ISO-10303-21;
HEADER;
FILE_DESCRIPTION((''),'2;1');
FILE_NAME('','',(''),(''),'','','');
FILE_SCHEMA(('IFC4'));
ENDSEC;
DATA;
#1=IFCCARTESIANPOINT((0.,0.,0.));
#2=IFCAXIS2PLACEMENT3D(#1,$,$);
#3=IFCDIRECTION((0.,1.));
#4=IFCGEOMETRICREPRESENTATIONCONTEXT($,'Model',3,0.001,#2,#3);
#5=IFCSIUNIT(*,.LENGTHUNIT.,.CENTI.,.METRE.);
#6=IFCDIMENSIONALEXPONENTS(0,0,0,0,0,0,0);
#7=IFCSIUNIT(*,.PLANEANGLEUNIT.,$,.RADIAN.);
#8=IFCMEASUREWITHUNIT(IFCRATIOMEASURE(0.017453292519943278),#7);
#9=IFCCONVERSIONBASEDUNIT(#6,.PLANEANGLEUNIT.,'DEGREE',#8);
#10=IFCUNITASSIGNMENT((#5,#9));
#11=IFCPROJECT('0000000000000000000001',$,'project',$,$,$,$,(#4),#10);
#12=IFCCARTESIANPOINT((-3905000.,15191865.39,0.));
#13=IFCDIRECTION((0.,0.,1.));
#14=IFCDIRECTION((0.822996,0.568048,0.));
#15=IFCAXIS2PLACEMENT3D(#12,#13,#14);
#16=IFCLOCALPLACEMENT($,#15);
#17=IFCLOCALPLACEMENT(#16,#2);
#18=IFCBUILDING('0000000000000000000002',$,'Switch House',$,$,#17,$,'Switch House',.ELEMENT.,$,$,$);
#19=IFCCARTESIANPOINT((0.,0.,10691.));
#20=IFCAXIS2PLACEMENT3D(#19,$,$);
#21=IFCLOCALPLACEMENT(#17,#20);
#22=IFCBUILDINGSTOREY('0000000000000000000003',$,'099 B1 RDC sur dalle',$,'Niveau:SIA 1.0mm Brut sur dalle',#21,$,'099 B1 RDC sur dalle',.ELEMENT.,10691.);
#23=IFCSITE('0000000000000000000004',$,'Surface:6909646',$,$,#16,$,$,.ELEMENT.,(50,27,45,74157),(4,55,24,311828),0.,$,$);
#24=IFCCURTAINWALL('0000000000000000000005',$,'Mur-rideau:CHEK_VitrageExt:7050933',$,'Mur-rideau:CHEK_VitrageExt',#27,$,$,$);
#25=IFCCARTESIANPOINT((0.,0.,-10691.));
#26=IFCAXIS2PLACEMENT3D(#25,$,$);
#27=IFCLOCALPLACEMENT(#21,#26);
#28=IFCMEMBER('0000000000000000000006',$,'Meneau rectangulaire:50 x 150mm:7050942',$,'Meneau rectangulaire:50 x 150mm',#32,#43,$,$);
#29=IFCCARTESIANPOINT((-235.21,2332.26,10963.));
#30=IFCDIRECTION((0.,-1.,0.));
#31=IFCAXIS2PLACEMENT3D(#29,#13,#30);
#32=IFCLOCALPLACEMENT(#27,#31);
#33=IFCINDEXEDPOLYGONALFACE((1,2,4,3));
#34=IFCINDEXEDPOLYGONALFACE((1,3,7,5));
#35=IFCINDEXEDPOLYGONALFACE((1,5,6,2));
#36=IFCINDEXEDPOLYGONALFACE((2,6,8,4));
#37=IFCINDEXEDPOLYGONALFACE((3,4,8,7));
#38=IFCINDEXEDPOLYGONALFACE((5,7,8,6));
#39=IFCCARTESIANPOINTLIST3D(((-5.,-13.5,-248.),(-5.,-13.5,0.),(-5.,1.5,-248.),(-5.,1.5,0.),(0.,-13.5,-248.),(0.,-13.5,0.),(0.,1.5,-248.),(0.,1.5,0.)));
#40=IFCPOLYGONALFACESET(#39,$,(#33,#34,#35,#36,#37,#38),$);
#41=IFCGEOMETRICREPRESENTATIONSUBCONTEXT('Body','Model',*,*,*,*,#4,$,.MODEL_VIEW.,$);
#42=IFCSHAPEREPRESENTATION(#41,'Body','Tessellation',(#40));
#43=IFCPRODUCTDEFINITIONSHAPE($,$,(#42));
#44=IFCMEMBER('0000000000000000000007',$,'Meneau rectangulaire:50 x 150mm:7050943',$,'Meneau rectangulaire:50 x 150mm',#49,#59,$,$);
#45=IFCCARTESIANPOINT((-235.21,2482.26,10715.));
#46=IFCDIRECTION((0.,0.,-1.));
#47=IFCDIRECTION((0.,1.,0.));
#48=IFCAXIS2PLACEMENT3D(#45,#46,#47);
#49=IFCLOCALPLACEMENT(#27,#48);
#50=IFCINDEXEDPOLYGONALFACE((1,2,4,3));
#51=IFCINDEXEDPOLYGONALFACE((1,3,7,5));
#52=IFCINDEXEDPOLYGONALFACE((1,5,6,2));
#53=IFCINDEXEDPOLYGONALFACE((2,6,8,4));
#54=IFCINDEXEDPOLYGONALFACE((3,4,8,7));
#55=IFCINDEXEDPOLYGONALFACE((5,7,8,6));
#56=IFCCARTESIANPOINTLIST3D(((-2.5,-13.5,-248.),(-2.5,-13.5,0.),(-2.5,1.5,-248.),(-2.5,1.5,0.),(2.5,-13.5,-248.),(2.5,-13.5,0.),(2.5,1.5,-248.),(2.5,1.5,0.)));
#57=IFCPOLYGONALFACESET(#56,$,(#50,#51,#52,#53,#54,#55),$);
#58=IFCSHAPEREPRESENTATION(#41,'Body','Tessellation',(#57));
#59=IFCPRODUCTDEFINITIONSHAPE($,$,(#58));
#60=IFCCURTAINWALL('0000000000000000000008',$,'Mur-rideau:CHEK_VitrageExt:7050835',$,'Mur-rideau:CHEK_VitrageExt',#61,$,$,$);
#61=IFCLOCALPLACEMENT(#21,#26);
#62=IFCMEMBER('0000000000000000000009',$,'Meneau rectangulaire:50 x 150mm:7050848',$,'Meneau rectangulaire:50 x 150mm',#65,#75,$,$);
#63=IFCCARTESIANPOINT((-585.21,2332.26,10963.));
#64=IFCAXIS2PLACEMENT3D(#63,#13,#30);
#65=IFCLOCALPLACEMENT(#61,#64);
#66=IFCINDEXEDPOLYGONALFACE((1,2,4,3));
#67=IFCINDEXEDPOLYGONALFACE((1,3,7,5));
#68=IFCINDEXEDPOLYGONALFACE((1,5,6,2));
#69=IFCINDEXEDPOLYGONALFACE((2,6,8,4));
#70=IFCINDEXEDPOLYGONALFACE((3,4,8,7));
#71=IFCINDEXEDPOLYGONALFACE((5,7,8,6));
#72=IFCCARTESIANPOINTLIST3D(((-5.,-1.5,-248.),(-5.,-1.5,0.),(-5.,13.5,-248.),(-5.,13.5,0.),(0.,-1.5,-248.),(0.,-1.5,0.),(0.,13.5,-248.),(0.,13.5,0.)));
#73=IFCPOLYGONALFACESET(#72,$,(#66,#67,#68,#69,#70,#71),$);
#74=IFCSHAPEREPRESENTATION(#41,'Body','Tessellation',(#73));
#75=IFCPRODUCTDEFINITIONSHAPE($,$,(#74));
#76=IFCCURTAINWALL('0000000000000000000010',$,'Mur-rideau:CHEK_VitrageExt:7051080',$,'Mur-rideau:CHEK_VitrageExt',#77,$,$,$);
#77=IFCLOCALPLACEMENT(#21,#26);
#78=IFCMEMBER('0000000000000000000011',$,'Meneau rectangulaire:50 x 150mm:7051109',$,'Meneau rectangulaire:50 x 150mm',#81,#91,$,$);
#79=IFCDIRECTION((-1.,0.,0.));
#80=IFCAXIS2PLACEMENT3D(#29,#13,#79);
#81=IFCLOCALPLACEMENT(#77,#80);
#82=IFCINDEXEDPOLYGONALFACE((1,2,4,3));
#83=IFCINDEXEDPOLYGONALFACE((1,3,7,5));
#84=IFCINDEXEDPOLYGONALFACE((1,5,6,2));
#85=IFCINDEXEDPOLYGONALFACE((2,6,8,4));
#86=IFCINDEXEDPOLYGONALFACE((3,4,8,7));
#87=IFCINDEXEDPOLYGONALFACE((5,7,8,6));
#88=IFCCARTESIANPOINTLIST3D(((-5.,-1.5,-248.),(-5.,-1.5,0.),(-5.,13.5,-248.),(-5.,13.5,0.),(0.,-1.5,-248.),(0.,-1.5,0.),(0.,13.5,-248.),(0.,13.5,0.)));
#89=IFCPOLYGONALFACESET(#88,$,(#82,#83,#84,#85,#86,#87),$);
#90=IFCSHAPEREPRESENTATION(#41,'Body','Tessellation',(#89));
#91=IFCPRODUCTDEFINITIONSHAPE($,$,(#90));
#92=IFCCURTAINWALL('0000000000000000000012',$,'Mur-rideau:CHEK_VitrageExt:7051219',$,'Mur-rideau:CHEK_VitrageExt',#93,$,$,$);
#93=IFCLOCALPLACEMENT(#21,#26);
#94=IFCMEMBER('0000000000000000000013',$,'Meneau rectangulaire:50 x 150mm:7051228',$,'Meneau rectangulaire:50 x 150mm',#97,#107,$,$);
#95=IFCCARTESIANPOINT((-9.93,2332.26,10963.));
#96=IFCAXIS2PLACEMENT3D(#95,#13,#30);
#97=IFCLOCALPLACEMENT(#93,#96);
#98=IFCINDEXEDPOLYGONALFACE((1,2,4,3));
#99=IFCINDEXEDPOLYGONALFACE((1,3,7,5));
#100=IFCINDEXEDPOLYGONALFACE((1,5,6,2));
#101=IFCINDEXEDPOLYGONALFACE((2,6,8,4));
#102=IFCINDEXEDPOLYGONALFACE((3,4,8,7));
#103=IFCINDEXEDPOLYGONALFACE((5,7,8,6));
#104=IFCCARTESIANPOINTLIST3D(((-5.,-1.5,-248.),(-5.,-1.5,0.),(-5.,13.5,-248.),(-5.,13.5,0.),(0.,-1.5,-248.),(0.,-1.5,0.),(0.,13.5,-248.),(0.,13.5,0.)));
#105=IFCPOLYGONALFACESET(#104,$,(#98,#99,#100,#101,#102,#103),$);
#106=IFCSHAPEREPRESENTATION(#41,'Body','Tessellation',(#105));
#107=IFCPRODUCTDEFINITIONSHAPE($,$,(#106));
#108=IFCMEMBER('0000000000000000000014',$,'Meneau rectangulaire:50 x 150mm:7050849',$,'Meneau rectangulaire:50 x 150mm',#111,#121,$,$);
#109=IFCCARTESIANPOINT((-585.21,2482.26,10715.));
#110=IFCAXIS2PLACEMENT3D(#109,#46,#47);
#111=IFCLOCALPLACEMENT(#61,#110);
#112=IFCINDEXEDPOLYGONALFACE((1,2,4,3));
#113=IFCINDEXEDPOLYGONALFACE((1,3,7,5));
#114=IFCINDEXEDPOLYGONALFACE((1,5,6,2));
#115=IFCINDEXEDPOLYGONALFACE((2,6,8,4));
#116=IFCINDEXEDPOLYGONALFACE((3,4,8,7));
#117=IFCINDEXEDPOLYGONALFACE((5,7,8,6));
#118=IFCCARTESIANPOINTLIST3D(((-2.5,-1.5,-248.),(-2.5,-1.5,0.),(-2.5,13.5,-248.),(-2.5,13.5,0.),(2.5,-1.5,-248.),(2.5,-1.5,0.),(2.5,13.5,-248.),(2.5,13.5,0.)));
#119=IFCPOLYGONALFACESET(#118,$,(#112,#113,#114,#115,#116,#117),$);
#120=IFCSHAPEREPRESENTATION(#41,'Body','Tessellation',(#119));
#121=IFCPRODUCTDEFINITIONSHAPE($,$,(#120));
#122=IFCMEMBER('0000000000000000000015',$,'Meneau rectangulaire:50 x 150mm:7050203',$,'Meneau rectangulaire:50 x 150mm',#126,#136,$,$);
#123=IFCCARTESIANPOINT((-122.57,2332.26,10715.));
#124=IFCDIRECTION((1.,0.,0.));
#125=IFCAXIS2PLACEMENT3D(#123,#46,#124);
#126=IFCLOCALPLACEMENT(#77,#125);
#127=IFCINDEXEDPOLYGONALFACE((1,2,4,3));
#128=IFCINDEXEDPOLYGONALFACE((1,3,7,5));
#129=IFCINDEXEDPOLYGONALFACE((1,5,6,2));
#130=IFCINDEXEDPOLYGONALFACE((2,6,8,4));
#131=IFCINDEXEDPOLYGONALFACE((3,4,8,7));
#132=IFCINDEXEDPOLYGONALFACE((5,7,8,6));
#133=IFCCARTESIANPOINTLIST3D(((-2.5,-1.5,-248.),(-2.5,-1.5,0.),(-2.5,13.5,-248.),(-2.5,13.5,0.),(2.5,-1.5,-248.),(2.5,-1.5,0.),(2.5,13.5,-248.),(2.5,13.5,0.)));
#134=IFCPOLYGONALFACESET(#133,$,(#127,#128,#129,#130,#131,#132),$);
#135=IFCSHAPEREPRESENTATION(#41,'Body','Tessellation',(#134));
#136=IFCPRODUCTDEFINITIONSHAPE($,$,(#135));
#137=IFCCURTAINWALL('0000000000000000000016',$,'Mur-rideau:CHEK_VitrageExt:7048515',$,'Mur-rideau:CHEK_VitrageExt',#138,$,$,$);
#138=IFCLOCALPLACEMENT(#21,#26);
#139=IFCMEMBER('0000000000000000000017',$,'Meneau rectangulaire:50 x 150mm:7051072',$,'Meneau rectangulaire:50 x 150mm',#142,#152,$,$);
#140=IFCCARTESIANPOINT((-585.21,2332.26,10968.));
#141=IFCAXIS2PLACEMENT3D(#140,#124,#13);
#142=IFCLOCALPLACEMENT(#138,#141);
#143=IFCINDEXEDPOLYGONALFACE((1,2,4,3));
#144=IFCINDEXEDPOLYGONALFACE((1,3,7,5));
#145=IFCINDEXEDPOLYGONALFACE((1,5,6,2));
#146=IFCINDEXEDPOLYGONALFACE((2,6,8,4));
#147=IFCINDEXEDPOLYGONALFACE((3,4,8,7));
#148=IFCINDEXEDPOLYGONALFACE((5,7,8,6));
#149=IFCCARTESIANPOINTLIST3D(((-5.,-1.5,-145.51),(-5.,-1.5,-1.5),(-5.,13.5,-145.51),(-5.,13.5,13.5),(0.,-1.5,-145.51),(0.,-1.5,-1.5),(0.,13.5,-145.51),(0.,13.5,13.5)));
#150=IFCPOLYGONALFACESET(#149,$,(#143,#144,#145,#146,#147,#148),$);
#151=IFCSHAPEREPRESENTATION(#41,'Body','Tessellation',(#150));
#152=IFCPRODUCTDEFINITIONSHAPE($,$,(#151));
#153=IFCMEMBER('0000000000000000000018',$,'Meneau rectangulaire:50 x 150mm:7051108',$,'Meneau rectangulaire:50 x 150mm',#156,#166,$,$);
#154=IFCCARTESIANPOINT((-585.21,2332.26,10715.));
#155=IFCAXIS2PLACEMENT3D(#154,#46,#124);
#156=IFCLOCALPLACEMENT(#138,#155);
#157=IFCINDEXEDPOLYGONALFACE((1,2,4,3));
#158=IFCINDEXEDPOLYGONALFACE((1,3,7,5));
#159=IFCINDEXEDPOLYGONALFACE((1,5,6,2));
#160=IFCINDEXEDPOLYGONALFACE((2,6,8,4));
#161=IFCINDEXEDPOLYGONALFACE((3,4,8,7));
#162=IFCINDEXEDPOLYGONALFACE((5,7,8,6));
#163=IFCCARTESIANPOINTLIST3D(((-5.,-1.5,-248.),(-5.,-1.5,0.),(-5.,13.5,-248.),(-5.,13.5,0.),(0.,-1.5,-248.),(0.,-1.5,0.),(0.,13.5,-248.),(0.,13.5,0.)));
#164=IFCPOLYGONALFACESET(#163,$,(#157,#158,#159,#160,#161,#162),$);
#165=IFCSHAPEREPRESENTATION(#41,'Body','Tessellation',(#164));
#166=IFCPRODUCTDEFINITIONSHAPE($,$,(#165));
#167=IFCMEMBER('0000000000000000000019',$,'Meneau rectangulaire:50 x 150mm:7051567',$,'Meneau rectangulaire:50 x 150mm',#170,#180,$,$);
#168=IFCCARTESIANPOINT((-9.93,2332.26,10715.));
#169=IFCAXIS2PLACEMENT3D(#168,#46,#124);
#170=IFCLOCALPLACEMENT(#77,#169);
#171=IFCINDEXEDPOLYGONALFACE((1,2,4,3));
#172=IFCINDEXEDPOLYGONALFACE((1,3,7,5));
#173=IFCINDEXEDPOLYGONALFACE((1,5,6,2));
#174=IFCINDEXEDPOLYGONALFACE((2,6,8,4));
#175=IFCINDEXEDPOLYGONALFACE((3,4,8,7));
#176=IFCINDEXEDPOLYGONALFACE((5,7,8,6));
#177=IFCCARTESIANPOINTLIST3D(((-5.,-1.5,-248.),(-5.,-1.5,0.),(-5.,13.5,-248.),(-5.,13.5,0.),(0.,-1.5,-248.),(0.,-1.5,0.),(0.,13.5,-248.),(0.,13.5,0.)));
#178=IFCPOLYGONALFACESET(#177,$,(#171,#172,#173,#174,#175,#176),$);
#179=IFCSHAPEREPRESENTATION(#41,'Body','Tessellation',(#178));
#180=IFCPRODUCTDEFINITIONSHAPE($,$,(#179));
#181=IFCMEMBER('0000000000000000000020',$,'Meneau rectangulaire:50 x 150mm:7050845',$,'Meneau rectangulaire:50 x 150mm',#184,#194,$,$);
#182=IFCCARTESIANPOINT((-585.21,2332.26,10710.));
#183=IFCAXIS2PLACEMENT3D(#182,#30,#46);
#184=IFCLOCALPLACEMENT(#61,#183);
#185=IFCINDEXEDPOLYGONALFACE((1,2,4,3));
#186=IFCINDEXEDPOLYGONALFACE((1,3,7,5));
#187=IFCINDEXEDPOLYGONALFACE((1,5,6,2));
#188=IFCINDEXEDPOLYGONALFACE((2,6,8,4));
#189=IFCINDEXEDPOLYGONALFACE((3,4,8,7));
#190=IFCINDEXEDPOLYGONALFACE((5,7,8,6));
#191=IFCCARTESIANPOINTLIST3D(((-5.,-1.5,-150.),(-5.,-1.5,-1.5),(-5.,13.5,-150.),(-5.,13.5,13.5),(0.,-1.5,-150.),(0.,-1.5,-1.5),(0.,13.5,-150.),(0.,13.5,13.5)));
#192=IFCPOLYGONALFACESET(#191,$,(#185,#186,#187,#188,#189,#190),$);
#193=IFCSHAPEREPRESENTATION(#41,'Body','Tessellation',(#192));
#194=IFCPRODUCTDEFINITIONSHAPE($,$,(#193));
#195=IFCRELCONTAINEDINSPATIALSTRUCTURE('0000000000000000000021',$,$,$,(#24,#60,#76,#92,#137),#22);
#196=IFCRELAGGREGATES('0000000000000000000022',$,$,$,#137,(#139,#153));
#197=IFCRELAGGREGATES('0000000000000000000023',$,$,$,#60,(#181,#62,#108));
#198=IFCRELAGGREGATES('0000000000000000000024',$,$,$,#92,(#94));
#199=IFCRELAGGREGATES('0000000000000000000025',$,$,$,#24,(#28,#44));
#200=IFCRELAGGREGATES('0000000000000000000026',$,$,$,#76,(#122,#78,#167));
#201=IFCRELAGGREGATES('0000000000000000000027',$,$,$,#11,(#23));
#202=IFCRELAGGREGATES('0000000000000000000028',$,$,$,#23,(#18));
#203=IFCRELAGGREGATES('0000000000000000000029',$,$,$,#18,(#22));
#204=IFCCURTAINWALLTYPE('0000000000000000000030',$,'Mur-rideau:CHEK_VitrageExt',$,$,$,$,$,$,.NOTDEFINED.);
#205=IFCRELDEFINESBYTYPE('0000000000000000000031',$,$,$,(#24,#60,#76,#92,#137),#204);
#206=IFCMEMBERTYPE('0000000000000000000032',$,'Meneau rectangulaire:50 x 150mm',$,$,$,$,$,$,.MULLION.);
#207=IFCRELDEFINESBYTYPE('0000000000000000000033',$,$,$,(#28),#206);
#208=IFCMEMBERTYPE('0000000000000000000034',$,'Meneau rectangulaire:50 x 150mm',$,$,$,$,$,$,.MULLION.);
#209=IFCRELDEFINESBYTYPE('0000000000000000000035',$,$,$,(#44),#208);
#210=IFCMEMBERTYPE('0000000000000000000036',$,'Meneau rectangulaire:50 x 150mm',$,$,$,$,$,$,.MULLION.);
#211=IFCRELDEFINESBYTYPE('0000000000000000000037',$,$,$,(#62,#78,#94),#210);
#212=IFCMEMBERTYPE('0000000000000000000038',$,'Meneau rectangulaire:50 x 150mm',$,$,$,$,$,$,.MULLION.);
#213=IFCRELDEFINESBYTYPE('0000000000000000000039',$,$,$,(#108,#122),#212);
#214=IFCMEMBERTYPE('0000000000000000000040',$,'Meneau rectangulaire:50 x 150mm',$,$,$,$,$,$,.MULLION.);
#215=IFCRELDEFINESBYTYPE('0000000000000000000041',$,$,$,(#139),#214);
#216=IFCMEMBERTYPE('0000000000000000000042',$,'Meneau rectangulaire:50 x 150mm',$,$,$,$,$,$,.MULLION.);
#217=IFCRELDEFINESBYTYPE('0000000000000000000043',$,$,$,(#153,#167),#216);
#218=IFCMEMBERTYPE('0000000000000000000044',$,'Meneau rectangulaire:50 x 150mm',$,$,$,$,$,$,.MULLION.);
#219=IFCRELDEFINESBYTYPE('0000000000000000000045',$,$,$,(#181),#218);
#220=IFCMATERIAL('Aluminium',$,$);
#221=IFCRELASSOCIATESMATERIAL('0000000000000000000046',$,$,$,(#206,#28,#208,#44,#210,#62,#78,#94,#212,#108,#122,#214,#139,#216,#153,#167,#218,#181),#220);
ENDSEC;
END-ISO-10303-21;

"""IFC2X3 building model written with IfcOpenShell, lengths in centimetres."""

from ifc_helpers import new_model, entity, si_unit, converted_unit, direction, frame, origin, origin_2d_with_axis, place, context, subcontext, project, spatial, rectangle, extrude, clip, halfspace, source, transform, mapped, material, type_object, type_shapes, element, aggregate, save


model = new_model("IFC2X3")

# Units and contexts
model_context = context("Model", 3, precision=0.001, world=origin(), true_north=direction((0.0, 1.0)))
body_context = subcontext(model_context, "Body", "Model", "MODEL_VIEW")
ifc_project = project(units=[si_unit("LENGTHUNIT", "METRE", prefix="CENTI"), converted_unit("PLANEANGLEUNIT", "DEGREE", entity("IfcRatioMeasure", 0.017453292519943278), si_unit("PLANEANGLEUNIT", "RADIAN"), dimensions=[0, 0, 0, 0, 0, 0, 0])], contexts=[model_context])

# Site, building, storey
site_placement = place(None, frame((-3905000.0, 15191865.39, 0.0), z_axis=(0.0, 0.0, 1.0), x_axis=(0.822996, 0.568048, 0.0)))
site = spatial("IfcSite", under=ifc_project, at=site_placement, Name="Surface:6909646", CompositionType="ELEMENT", RefLatitude=(50, 27, 45, 74157), RefLongitude=(4, 55, 24, 311828), RefElevation=0.0)
building_placement = place(site_placement, origin())
building = spatial("IfcBuilding", under=site, at=building_placement, Name="Switch House", LongName="Switch House", CompositionType="ELEMENT")
storey_placement = place(building_placement, frame((0.0, 0.0, 10691.0)))
storey = spatial("IfcBuildingStorey", under=building, at=storey_placement, Name="099 B1 RDC sur dalle", ObjectType="Niveau:SIA 1.0mm Brut sur dalle", LongName="099 B1 RDC sur dalle", CompositionType="ELEMENT", Elevation=10691.0)

# Curtain wall, members
curtain_wall_type = type_object("IfcCurtainWallType", Name="Mur-rideau:CHEK_VitrageExt", PredefinedType="NOTDEFINED")
curtain_wall_1_placement = place(storey_placement, frame((0.0, 0.0, -10691.0)))
curtain_wall_1 = element("IfcCurtainWall", 1, at=curtain_wall_1_placement, inside=storey, type_object=curtain_wall_type, Name="Mur-rideau:CHEK_VitrageExt:7050933", ObjectType="Mur-rideau:CHEK_VitrageExt")
ifc_material_1 = material(Name="Aluminium")
member_type_1 = type_object("IfcMemberType", Name="Meneau rectangulaire:50 x 150mm", PredefinedType="MULLION", material=ifc_material_1)
shared_shape_1 = source(origin(), body_context, "Body", "SweptSolid", [
    extrude(rectangle(XDim=15.0, YDim=5.0, at=origin_2d_with_axis()), frame((-2.5, -6.0, -248.0), z_axis=(0.0, 0.0, 1.0), x_axis=(0.0, -1.0, 0.0)), (0.0, 0.0, 1.0), 248.0),
])
type_shapes(member_type_1, [shared_shape_1])
member_1_placement = place(curtain_wall_1_placement, frame((-235.21, 2332.26, 10963.0), z_axis=(0.0, 0.0, 1.0), x_axis=(0.0, -1.0, 0.0)))
member_1 = element("IfcMember", 2, at=member_1_placement, type_object=member_type_1, material=ifc_material_1, Name="Meneau rectangulaire:50 x 150mm:7050942", ObjectType="Meneau rectangulaire:50 x 150mm", context=body_context, shape_type="MappedRepresentation", body=[
    mapped(shared_shape_1, transform((0.0, 0.0, 0.0), scale=1.0)),
])
member_type_2 = type_object("IfcMemberType", Name="Meneau rectangulaire:50 x 150mm", PredefinedType="MULLION", material=ifc_material_1)
shared_shape_2 = source(origin(), body_context, "Body", "SweptSolid", [
    extrude(rectangle(XDim=15.0, YDim=5.0, at=origin_2d_with_axis()), frame((0.0, -6.0, -248.0), z_axis=(0.0, 0.0, 1.0), x_axis=(0.0, -1.0, 0.0)), (0.0, 0.0, 1.0), 248.0),
])
type_shapes(member_type_2, [shared_shape_2])
member_2_placement = place(curtain_wall_1_placement, frame((-235.21, 2482.26, 10715.0), z_axis=(0.0, 0.0, -1.0), x_axis=(0.0, 1.0, 0.0)))
member_2 = element("IfcMember", 3, at=member_2_placement, type_object=member_type_2, material=ifc_material_1, Name="Meneau rectangulaire:50 x 150mm:7050943", ObjectType="Meneau rectangulaire:50 x 150mm", context=body_context, shape_type="MappedRepresentation", body=[
    mapped(shared_shape_2, transform((0.0, 0.0, 0.0), scale=1.0)),
])

# Curtain walls, members
curtain_wall_2_placement = place(storey_placement, frame((0.0, 0.0, -10691.0)))
curtain_wall_2 = element("IfcCurtainWall", 4, at=curtain_wall_2_placement, inside=storey, type_object=curtain_wall_type, Name="Mur-rideau:CHEK_VitrageExt:7050835", ObjectType="Mur-rideau:CHEK_VitrageExt")
member_type_3 = type_object("IfcMemberType", Name="Meneau rectangulaire:50 x 150mm", PredefinedType="MULLION", material=ifc_material_1)
shared_shape_3 = source(origin(), body_context, "Body", "SweptSolid", [
    extrude(rectangle(XDim=15.0, YDim=5.0, at=origin_2d_with_axis()), frame((-2.5, 6.0, -248.0), z_axis=(0.0, 0.0, 1.0), x_axis=(0.0, -1.0, 0.0)), (0.0, 0.0, 1.0), 248.0),
])
type_shapes(member_type_3, [shared_shape_3])
member_3_placement = place(curtain_wall_2_placement, frame((-585.21, 2332.26, 10963.0), z_axis=(0.0, 0.0, 1.0), x_axis=(0.0, -1.0, 0.0)))
member_3 = element("IfcMember", 5, at=member_3_placement, type_object=member_type_3, material=ifc_material_1, Name="Meneau rectangulaire:50 x 150mm:7050848", ObjectType="Meneau rectangulaire:50 x 150mm", context=body_context, shape_type="MappedRepresentation", body=[
    mapped(shared_shape_3, transform((0.0, 0.0, 0.0), scale=1.0)),
])
curtain_wall_3_placement = place(storey_placement, frame((0.0, 0.0, -10691.0)))
curtain_wall_3 = element("IfcCurtainWall", 6, at=curtain_wall_3_placement, inside=storey, type_object=curtain_wall_type, Name="Mur-rideau:CHEK_VitrageExt:7051080", ObjectType="Mur-rideau:CHEK_VitrageExt")
member_4_placement = place(curtain_wall_3_placement, frame((-235.21, 2332.26, 10963.0), z_axis=(0.0, 0.0, 1.0), x_axis=(-1.0, 0.0, 0.0)))
member_4 = element("IfcMember", 7, at=member_4_placement, type_object=member_type_3, material=ifc_material_1, Name="Meneau rectangulaire:50 x 150mm:7051109", ObjectType="Meneau rectangulaire:50 x 150mm", context=body_context, shape_type="MappedRepresentation", body=[
    mapped(shared_shape_3, transform((0.0, 0.0, 0.0), scale=1.0)),
])
curtain_wall_4_placement = place(storey_placement, frame((0.0, 0.0, -10691.0)))
curtain_wall_4 = element("IfcCurtainWall", 8, at=curtain_wall_4_placement, inside=storey, type_object=curtain_wall_type, Name="Mur-rideau:CHEK_VitrageExt:7051219", ObjectType="Mur-rideau:CHEK_VitrageExt")
member_5_placement = place(curtain_wall_4_placement, frame((-9.93, 2332.26, 10963.0), z_axis=(0.0, 0.0, 1.0), x_axis=(0.0, -1.0, 0.0)))
member_5 = element("IfcMember", 9, at=member_5_placement, type_object=member_type_3, material=ifc_material_1, Name="Meneau rectangulaire:50 x 150mm:7051228", ObjectType="Meneau rectangulaire:50 x 150mm", context=body_context, shape_type="MappedRepresentation", body=[
    mapped(shared_shape_3, transform((0.0, 0.0, 0.0), scale=1.0)),
])

# Members
member_type_4 = type_object("IfcMemberType", Name="Meneau rectangulaire:50 x 150mm", PredefinedType="MULLION", material=ifc_material_1)
shared_shape_4 = source(origin(), body_context, "Body", "SweptSolid", [
    extrude(rectangle(XDim=15.0, YDim=5.0, at=origin_2d_with_axis()), frame((0.0, 6.0, -248.0), z_axis=(0.0, 0.0, 1.0), x_axis=(0.0, -1.0, 0.0)), (0.0, 0.0, 1.0), 248.0),
])
type_shapes(member_type_4, [shared_shape_4])
member_6_placement = place(curtain_wall_2_placement, frame((-585.21, 2482.26, 10715.0), z_axis=(0.0, 0.0, -1.0), x_axis=(0.0, 1.0, 0.0)))
member_6 = element("IfcMember", 10, at=member_6_placement, type_object=member_type_4, material=ifc_material_1, Name="Meneau rectangulaire:50 x 150mm:7050849", ObjectType="Meneau rectangulaire:50 x 150mm", context=body_context, shape_type="MappedRepresentation", body=[
    mapped(shared_shape_4, transform((0.0, 0.0, 0.0), scale=1.0)),
])
member_7_placement = place(curtain_wall_3_placement, frame((-122.57, 2332.26, 10715.0), z_axis=(0.0, 0.0, -1.0), x_axis=(1.0, 0.0, 0.0)))
member_7 = element("IfcMember", 11, at=member_7_placement, type_object=member_type_4, material=ifc_material_1, Name="Meneau rectangulaire:50 x 150mm:7050203", ObjectType="Meneau rectangulaire:50 x 150mm", context=body_context, shape_type="MappedRepresentation", body=[
    mapped(shared_shape_4, transform((0.0, 0.0, 0.0), scale=1.0)),
])

# Curtain wall, members
curtain_wall_5_placement = place(storey_placement, frame((0.0, 0.0, -10691.0)))
curtain_wall_5 = element("IfcCurtainWall", 12, at=curtain_wall_5_placement, inside=storey, type_object=curtain_wall_type, Name="Mur-rideau:CHEK_VitrageExt:7048515", ObjectType="Mur-rideau:CHEK_VitrageExt")
member_type_5 = type_object("IfcMemberType", Name="Meneau rectangulaire:50 x 150mm", PredefinedType="MULLION", material=ifc_material_1)
shared_shape_5 = source(origin(), body_context, "Body", "SweptSolid", [
    clip(extrude(rectangle(XDim=15.0, YDim=5.0, at=origin_2d_with_axis()), frame((-2.5, 6.0, -145.51), z_axis=(0.0, 0.0, 1.0), x_axis=(0.0, -1.0, 0.0)), (0.0, 0.0, 1.0), 159.01), halfspace(frame((30.48, 0.0, 0.0), z_axis=(0.0, -0.707107, 0.707107), x_axis=(0.0, -0.707107, -0.707107)), False)),
])
type_shapes(member_type_5, [shared_shape_5])
member_8_placement = place(curtain_wall_5_placement, frame((-585.21, 2332.26, 10968.0), z_axis=(1.0, 0.0, 0.0), x_axis=(0.0, 0.0, 1.0)))
member_8 = element("IfcMember", 13, at=member_8_placement, type_object=member_type_5, material=ifc_material_1, Name="Meneau rectangulaire:50 x 150mm:7051072", ObjectType="Meneau rectangulaire:50 x 150mm", context=body_context, shape_type="MappedRepresentation", body=[
    mapped(shared_shape_5, transform((0.0, 0.0, 0.0), scale=1.0)),
])
member_type_6 = type_object("IfcMemberType", Name="Meneau rectangulaire:50 x 150mm", PredefinedType="MULLION", material=ifc_material_1)
shared_shape_6 = source(origin(), body_context, "Body", "SweptSolid", [
    extrude(rectangle(XDim=15.0, YDim=5.0, at=origin_2d_with_axis()), frame((-2.5, 6.0, -248.0), z_axis=(0.0, 0.0, 1.0), x_axis=(0.0, -1.0, 0.0)), (0.0, 0.0, 1.0), 248.0),
])
type_shapes(member_type_6, [shared_shape_6])
member_9_placement = place(curtain_wall_5_placement, frame((-585.21, 2332.26, 10715.0), z_axis=(0.0, 0.0, -1.0), x_axis=(1.0, 0.0, 0.0)))
member_9 = element("IfcMember", 14, at=member_9_placement, type_object=member_type_6, material=ifc_material_1, Name="Meneau rectangulaire:50 x 150mm:7051108", ObjectType="Meneau rectangulaire:50 x 150mm", context=body_context, shape_type="MappedRepresentation", body=[
    mapped(shared_shape_6, transform((0.0, 0.0, 0.0), scale=1.0)),
])

# Members
member_10_placement = place(curtain_wall_3_placement, frame((-9.93, 2332.26, 10715.0), z_axis=(0.0, 0.0, -1.0), x_axis=(1.0, 0.0, 0.0)))
member_10 = element("IfcMember", 15, at=member_10_placement, type_object=member_type_6, material=ifc_material_1, Name="Meneau rectangulaire:50 x 150mm:7051567", ObjectType="Meneau rectangulaire:50 x 150mm", context=body_context, shape_type="MappedRepresentation", body=[
    mapped(shared_shape_6, transform((0.0, 0.0, 0.0), scale=1.0)),
])
member_type_7 = type_object("IfcMemberType", Name="Meneau rectangulaire:50 x 150mm", PredefinedType="MULLION", material=ifc_material_1)
shared_shape_7 = source(origin(), body_context, "Body", "SweptSolid", [
    clip(extrude(rectangle(XDim=15.0, YDim=5.0, at=origin_2d_with_axis()), frame((-2.5, 6.0, -150.0), z_axis=(0.0, 0.0, 1.0), x_axis=(0.0, -1.0, 0.0)), (0.0, 0.0, 1.0), 163.5), halfspace(frame((30.48, 0.0, 0.0), z_axis=(0.0, -0.707107, 0.707107), x_axis=(0.0, -0.707107, -0.707107)), False)),
])
type_shapes(member_type_7, [shared_shape_7])
member_11_placement = place(curtain_wall_2_placement, frame((-585.21, 2332.26, 10710.0), z_axis=(0.0, -1.0, 0.0), x_axis=(0.0, 0.0, -1.0)))
member_11 = element("IfcMember", 16, at=member_11_placement, type_object=member_type_7, material=ifc_material_1, Name="Meneau rectangulaire:50 x 150mm:7050845", ObjectType="Meneau rectangulaire:50 x 150mm", context=body_context, shape_type="MappedRepresentation", body=[
    mapped(shared_shape_7, transform((0.0, 0.0, 0.0), scale=1.0)),
])

aggregate(curtain_wall_5, [member_8, member_9])
aggregate(curtain_wall_2, [member_11, member_3, member_6])
aggregate(curtain_wall_4, [member_5])
aggregate(curtain_wall_1, [member_1, member_2])
aggregate(curtain_wall_3, [member_7, member_4, member_10])

save(model, "model.ifc")
